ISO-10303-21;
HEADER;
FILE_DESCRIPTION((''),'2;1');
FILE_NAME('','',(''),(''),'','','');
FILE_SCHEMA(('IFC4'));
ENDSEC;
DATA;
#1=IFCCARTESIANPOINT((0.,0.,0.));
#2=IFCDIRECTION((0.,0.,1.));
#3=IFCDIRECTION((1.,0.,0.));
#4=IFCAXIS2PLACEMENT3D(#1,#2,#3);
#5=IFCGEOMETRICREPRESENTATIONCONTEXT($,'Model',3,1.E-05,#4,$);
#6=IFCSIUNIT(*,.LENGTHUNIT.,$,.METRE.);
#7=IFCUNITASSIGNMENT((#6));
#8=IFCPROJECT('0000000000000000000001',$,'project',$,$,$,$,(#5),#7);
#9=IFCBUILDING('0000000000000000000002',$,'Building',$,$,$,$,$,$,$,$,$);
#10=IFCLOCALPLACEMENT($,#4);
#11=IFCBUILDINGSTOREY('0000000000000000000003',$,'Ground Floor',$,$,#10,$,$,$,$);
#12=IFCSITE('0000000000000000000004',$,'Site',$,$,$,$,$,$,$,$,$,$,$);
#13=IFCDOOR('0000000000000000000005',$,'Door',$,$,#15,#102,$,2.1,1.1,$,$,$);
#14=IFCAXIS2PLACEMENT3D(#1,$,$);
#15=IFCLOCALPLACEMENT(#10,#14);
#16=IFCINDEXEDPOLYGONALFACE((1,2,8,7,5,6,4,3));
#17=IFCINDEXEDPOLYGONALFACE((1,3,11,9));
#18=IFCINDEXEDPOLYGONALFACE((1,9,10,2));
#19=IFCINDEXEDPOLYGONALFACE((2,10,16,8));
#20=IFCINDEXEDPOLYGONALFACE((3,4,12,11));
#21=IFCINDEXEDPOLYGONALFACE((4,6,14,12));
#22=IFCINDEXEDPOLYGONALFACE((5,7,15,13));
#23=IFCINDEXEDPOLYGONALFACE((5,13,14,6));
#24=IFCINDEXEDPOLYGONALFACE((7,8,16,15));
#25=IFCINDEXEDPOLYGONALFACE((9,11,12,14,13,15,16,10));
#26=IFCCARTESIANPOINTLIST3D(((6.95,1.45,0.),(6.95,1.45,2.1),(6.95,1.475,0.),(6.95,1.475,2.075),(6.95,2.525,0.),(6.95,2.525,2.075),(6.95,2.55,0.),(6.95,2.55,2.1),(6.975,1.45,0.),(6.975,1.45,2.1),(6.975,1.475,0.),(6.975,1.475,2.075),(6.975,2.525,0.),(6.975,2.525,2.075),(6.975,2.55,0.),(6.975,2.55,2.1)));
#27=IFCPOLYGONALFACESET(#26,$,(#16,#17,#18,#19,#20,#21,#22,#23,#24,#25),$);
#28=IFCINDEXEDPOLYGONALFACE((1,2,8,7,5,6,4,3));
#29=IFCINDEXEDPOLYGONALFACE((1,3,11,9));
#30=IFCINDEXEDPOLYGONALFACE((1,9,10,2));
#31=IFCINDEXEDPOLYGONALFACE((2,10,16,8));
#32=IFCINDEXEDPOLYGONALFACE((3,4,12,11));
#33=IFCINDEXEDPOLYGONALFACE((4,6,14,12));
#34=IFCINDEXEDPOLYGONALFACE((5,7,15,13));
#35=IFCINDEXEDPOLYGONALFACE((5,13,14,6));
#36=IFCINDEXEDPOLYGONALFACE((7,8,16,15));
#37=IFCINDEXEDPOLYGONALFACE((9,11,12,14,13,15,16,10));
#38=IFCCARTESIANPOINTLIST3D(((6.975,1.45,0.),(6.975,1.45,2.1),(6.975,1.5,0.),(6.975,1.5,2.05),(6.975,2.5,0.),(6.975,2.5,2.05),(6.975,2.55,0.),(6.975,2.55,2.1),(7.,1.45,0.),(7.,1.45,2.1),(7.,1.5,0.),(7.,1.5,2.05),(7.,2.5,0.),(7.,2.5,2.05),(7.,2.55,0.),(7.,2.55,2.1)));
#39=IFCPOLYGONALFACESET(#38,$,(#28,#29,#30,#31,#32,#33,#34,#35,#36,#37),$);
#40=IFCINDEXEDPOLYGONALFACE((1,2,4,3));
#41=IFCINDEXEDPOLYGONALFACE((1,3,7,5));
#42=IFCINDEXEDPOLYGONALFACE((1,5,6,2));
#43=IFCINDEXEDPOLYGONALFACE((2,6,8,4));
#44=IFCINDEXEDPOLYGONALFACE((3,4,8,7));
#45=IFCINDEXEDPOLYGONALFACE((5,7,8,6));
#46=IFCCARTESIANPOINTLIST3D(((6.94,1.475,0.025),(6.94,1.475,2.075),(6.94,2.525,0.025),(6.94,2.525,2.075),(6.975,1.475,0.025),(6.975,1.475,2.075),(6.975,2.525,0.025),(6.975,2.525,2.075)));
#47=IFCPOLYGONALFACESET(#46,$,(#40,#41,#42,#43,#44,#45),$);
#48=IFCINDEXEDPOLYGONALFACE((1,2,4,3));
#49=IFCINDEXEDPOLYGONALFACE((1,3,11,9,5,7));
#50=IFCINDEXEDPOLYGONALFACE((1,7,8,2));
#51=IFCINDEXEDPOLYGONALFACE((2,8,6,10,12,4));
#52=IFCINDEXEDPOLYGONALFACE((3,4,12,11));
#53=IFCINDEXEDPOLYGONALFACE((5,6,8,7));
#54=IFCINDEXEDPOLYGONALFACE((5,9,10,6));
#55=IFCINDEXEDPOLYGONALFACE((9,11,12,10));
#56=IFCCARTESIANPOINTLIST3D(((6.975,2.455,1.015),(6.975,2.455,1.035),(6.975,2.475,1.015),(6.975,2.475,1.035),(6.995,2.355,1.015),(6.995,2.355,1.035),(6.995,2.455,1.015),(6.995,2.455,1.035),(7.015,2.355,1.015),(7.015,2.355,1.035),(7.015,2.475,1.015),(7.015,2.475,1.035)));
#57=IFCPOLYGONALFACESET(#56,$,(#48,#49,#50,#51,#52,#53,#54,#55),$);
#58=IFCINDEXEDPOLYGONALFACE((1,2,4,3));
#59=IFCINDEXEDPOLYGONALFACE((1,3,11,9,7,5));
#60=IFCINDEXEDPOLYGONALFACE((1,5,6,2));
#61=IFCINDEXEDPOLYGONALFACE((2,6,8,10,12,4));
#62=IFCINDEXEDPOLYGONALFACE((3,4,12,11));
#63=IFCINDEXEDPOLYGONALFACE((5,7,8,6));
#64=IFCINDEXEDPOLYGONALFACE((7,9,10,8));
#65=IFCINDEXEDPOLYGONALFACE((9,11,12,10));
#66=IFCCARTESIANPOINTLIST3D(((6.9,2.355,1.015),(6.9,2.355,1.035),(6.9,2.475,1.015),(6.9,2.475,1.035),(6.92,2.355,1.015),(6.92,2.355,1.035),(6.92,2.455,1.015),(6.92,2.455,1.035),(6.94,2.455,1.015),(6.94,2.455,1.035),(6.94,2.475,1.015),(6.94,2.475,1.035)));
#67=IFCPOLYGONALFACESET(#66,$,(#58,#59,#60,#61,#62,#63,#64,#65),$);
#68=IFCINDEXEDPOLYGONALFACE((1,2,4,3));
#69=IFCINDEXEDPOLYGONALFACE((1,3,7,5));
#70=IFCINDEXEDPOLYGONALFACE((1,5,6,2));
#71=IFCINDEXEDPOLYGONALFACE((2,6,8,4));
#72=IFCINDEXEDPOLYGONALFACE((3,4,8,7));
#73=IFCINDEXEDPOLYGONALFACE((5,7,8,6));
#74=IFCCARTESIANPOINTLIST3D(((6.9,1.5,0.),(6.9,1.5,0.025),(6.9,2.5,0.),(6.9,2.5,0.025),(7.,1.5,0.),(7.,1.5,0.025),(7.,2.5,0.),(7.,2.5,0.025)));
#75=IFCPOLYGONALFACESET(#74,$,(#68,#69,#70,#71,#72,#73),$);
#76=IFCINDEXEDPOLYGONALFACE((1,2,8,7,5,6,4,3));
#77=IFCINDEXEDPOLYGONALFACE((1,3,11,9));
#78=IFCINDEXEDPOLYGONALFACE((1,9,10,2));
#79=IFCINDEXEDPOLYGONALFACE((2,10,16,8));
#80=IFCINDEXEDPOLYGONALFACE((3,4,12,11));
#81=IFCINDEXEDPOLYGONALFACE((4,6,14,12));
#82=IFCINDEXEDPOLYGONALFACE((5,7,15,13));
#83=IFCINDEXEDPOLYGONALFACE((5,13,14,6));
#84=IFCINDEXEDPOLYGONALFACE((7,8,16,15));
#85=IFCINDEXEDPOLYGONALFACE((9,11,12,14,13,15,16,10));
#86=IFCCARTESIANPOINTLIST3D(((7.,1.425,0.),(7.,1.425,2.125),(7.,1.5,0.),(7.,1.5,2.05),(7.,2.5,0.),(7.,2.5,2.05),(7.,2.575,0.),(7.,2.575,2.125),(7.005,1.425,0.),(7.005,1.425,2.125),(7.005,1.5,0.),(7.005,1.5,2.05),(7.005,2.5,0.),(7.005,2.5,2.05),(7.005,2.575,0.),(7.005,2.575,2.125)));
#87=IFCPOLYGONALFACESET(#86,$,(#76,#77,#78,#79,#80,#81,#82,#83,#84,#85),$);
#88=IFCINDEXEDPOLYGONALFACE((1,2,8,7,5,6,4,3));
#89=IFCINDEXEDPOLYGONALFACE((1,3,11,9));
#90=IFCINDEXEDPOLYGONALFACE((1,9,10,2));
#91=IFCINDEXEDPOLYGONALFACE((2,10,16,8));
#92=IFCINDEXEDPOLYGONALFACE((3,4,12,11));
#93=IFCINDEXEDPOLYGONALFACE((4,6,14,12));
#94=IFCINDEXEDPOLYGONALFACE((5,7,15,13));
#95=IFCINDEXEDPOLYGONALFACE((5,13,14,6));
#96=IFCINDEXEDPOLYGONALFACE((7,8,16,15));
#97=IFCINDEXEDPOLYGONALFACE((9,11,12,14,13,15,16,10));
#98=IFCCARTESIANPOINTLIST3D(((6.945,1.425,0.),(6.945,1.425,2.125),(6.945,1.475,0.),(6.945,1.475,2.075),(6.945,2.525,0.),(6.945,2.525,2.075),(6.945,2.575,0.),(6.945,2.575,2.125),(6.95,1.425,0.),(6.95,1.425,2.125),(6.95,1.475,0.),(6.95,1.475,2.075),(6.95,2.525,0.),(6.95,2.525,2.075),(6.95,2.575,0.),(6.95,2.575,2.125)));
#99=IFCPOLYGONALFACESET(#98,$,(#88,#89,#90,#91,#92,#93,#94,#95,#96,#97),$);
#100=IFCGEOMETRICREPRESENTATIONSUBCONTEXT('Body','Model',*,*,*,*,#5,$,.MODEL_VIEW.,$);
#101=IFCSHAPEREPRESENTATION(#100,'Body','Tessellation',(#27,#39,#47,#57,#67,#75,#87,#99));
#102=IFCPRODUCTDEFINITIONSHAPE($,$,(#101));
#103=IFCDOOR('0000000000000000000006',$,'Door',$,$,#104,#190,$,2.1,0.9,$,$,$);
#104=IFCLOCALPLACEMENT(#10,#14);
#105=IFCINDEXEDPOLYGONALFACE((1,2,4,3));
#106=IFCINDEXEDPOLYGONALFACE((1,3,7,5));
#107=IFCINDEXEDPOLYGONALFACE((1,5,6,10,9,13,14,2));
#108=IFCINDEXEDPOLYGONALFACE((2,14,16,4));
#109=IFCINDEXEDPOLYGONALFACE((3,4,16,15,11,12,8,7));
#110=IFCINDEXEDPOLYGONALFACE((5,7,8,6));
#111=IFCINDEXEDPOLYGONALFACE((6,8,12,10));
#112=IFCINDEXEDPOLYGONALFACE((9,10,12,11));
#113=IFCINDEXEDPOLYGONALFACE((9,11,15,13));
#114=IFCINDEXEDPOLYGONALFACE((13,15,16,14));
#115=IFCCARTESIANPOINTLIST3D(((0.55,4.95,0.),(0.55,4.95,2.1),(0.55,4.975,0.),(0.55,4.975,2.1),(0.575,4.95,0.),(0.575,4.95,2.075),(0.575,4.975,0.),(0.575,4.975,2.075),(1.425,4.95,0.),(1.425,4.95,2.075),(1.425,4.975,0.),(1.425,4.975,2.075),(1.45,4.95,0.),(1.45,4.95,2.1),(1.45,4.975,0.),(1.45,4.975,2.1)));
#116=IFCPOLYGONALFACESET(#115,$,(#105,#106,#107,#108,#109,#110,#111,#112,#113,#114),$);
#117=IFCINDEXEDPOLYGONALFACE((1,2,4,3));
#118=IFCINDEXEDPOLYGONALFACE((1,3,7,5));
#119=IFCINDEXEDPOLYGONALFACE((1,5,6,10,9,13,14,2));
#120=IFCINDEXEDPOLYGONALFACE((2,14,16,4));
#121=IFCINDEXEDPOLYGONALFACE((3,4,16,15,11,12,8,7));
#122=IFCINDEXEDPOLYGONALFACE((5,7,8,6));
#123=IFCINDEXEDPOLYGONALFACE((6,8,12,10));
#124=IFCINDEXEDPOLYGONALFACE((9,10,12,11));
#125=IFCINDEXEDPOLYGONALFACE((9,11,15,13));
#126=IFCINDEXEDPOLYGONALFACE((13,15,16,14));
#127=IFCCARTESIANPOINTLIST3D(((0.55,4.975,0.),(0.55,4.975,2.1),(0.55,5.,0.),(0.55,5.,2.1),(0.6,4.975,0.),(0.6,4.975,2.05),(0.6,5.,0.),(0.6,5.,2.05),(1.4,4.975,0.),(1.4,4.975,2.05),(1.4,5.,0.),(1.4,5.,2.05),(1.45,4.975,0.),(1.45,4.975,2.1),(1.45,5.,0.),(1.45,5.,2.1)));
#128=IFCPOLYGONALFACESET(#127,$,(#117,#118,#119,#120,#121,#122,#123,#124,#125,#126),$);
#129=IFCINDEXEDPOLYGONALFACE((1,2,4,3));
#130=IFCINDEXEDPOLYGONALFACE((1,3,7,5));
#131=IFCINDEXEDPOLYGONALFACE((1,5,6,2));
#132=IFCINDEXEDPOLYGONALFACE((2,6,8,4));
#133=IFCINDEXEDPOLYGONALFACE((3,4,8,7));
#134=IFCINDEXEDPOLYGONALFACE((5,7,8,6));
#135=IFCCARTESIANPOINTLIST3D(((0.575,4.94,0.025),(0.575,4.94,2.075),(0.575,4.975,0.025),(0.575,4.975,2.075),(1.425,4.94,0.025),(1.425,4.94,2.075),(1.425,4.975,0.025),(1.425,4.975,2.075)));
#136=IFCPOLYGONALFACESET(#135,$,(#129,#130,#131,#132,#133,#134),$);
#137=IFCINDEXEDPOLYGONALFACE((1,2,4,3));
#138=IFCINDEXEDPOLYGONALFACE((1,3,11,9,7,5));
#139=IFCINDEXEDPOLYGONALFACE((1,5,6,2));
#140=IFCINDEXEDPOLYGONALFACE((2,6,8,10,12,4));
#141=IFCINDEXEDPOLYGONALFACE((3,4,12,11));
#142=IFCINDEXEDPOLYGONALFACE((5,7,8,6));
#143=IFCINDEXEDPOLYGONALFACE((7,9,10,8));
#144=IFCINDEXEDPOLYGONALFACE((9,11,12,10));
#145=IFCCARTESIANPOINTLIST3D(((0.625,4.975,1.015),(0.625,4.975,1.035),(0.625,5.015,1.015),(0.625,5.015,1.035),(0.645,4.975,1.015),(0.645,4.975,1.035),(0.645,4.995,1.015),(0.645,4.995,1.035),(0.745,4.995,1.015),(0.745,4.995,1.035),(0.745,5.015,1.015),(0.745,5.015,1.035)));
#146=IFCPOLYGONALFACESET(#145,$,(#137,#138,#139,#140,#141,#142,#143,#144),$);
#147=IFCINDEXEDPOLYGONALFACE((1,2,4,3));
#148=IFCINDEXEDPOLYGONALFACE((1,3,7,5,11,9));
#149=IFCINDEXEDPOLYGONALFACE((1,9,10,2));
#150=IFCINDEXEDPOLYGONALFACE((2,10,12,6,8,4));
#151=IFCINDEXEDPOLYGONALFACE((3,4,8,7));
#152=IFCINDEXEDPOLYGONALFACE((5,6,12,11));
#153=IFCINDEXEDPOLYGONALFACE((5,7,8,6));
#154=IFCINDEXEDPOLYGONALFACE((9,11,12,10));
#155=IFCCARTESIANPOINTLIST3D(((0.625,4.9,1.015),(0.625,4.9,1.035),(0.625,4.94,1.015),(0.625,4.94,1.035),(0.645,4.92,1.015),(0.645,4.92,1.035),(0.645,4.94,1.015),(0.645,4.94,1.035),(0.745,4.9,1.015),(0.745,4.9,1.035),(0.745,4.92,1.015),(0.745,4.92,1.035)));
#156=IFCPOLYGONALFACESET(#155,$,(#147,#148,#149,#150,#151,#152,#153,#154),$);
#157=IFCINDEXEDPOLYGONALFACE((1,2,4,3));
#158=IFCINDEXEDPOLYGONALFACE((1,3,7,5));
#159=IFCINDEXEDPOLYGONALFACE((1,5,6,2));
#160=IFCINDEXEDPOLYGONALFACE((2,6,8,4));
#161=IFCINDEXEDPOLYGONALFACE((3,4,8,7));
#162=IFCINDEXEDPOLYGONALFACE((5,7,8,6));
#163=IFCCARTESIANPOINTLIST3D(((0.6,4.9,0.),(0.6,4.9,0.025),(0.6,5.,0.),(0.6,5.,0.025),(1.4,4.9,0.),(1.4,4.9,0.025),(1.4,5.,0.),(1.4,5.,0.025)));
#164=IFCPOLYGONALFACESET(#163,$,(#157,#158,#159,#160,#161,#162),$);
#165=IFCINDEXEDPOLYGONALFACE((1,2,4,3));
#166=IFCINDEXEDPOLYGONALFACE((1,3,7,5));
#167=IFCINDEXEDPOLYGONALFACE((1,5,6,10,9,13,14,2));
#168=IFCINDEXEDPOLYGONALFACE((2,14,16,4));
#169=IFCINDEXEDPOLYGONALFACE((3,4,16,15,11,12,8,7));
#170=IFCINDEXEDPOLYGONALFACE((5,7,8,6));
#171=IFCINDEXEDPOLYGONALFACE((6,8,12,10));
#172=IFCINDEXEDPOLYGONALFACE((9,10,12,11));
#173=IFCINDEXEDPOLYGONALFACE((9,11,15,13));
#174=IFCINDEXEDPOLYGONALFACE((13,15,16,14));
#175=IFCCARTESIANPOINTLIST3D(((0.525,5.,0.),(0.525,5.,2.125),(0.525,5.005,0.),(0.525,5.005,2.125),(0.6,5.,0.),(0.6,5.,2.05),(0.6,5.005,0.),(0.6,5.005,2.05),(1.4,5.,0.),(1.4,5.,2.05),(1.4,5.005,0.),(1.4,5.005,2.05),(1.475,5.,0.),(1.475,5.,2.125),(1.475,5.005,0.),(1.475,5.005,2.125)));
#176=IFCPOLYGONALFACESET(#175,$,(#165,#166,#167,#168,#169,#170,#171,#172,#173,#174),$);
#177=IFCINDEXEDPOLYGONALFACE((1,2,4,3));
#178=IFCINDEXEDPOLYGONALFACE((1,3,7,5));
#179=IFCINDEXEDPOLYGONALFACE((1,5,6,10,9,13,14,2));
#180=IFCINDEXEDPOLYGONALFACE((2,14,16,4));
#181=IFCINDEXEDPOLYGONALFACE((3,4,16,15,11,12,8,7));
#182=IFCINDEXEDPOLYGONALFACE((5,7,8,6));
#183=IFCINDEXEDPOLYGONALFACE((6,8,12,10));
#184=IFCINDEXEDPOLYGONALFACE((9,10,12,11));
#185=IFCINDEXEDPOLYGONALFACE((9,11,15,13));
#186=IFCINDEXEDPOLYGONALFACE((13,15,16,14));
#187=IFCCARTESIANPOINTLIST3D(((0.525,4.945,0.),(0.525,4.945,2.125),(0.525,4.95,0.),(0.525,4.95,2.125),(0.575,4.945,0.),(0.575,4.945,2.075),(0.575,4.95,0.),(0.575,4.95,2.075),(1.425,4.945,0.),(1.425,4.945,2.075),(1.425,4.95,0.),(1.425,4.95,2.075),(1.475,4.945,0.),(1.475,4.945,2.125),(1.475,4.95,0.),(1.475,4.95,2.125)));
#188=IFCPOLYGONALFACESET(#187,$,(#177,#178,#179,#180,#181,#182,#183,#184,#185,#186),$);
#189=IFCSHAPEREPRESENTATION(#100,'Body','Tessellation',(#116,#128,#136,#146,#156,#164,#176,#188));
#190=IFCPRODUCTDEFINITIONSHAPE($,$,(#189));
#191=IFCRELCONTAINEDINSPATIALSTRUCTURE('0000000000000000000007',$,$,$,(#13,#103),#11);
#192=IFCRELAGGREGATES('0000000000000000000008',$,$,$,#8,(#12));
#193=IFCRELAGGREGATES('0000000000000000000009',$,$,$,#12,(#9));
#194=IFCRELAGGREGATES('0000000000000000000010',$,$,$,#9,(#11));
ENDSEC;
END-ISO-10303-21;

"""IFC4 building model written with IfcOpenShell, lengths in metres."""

from ifc_helpers import new_model, si_unit, frame, origin_with_axes, place, context, subcontext, project, spatial, line, indexed_curve, outline, extrude, element, save


model = new_model("IFC4")

# Units and contexts
model_context = context("Model", 3, precision=1e-05, world=origin_with_axes())
body_context = subcontext(model_context, "Body", "Model", "MODEL_VIEW")
ifc_project = project(units=[si_unit("LENGTHUNIT", "METRE")], contexts=[model_context])

# Site, building, storey
site = spatial("IfcSite", under=ifc_project, Name="Site")
building = spatial("IfcBuilding", under=site, Name="Building")
storey_placement = place(None, origin_with_axes())
storey = spatial("IfcBuildingStorey", under=building, at=storey_placement, Name="Ground Floor")

# Doors
door_1_placement = place(storey_placement, frame((7.0, 1.45, 0.0), z_axis=(0.0, 0.0, 1.0), x_axis=(0.0, 1.0, 0.0)))
element("IfcDoor", 1, at=door_1_placement, inside=storey, Name="Door", OverallHeight=2.1, OverallWidth=1.1, context=body_context, shape_type="SweptSolid", body=[
    extrude(outline(indexed_curve([(0.0, 0.0), (0.0, 2.1), (1.1, 2.1), (1.1, 0.0), (1.075, 0.0), (1.075, 2.075), (0.025, 2.075), (0.025, 0.0)], segments=[line(1, 2, 3, 4, 5, 6, 7, 8, 1)])), frame((0.0, 0.025, 0.0), z_axis=(0.0, -1.0, 0.0), x_axis=(1.0, 0.0, 0.0)), (0.0, 0.0, -1.0), 0.025),
    extrude(outline(indexed_curve([(0.0, 0.0), (0.0, 2.1), (1.1, 2.1), (1.1, 0.0), (1.05, 0.0), (1.05, 2.05), (0.05, 2.05), (0.05, 0.0)], segments=[line(1, 2, 3, 4, 5, 6, 7, 8, 1)])), frame((0.0, 0.0, 0.0), z_axis=(0.0, -1.0, 0.0), x_axis=(1.0, 0.0, 0.0)), (0.0, 0.0, -1.0), 0.025),
    extrude(outline(indexed_curve([(0.0, 0.0), (1.05, 0.0), (1.05, 0.035), (0.0, 0.035)], segments=[line(1, 2, 3, 4, 1)])), frame((0.025, 0.025, 0.025), z_axis=(0.0, 0.0, 1.0), x_axis=(1.0, 0.0, 0.0)), (0.0, 0.0, 1.0), 2.05),
    extrude(outline(indexed_curve([(0.0, 0.0), (0.0, -0.04), (-0.12, -0.04), (-0.12, -0.02), (-0.02, -0.02), (-0.02, 0.0)], segments=[line(1, 2, 3, 4, 5, 6, 1)])), frame((1.025, 0.025, 1.015), z_axis=(0.0, 0.0, 1.0), x_axis=(1.0, 0.0, 0.0)), (0.0, 0.0, 1.0), 0.02),
    extrude(outline(indexed_curve([(0.0, 0.0), (0.0, 0.04), (-0.12, 0.04), (-0.12, 0.02), (-0.02, 0.02), (-0.02, 0.0)], segments=[line(1, 2, 3, 4, 5, 6, 1)])), frame((1.025, 0.06, 1.015), z_axis=(0.0, 0.0, 1.0), x_axis=(1.0, 0.0, 0.0)), (0.0, 0.0, 1.0), 0.02),
    extrude(outline(indexed_curve([(0.0, 0.0), (1.0, 0.0), (1.0, 0.1), (0.0, 0.1)], segments=[line(1, 2, 3, 4, 1)])), frame((0.05, 0.0, 0.0), z_axis=(0.0, 0.0, 1.0), x_axis=(1.0, 0.0, 0.0)), (0.0, 0.0, 1.0), 0.025),
    extrude(outline(indexed_curve([(0.0, 0.0), (0.0, 2.125), (1.15, 2.125), (1.15, 0.0), (1.075, 0.0), (1.075, 2.05), (0.075, 2.05), (0.075, 0.0)], segments=[line(1, 2, 3, 4, 5, 6, 7, 8, 1)])), frame((-0.025, -0.005, 0.0), z_axis=(0.0, -1.0, 0.0), x_axis=(1.0, 0.0, 0.0)), (0.0, 0.0, -1.0), 0.005),
    extrude(outline(indexed_curve([(0.0, 0.0), (0.0, 2.125), (1.15, 2.125), (1.15, 0.0), (1.1, 0.0), (1.1, 2.075), (0.05, 2.075), (0.05, 0.0)], segments=[line(1, 2, 3, 4, 5, 6, 7, 8, 1)])), frame((-0.025, 0.05, 0.0), z_axis=(0.0, -1.0, 0.0), x_axis=(1.0, 0.0, 0.0)), (0.0, 0.0, -1.0), 0.005),
])
door_2_placement = place(storey_placement, frame((1.45, 5.0, 0.0), z_axis=(0.0, 0.0, 1.0), x_axis=(-1.0, 0.0, 0.0)))
element("IfcDoor", 2, at=door_2_placement, inside=storey, Name="Door", OverallHeight=2.1, OverallWidth=0.9, context=body_context, shape_type="SweptSolid", body=[
    extrude(outline(indexed_curve([(0.0, 0.0), (0.0, 2.1), (0.9, 2.1), (0.9, 0.0), (0.875, 0.0), (0.875, 2.075), (0.025, 2.075), (0.025, 0.0)], segments=[line(1, 2, 3, 4, 5, 6, 7, 8, 1)])), frame((0.0, 0.025, 0.0), z_axis=(0.0, -1.0, 0.0), x_axis=(1.0, 0.0, 0.0)), (0.0, 0.0, -1.0), 0.025),
    extrude(outline(indexed_curve([(0.0, 0.0), (0.0, 2.1), (0.9, 2.1), (0.9, 0.0), (0.85, 0.0), (0.85, 2.05), (0.05, 2.05), (0.05, 0.0)], segments=[line(1, 2, 3, 4, 5, 6, 7, 8, 1)])), frame((0.0, 0.0, 0.0), z_axis=(0.0, -1.0, 0.0), x_axis=(1.0, 0.0, 0.0)), (0.0, 0.0, -1.0), 0.025),
    extrude(outline(indexed_curve([(0.0, 0.0), (0.85, 0.0), (0.85, 0.035), (0.0, 0.035)], segments=[line(1, 2, 3, 4, 1)])), frame((0.025, 0.025, 0.025), z_axis=(0.0, 0.0, 1.0), x_axis=(1.0, 0.0, 0.0)), (0.0, 0.0, 1.0), 2.05),
    extrude(outline(indexed_curve([(0.0, 0.0), (0.0, -0.04), (-0.12, -0.04), (-0.12, -0.02), (-0.02, -0.02), (-0.02, 0.0)], segments=[line(1, 2, 3, 4, 5, 6, 1)])), frame((0.825, 0.025, 1.015), z_axis=(0.0, 0.0, 1.0), x_axis=(1.0, 0.0, 0.0)), (0.0, 0.0, 1.0), 0.02),
    extrude(outline(indexed_curve([(0.0, 0.0), (0.0, 0.04), (-0.12, 0.04), (-0.12, 0.02), (-0.02, 0.02), (-0.02, 0.0)], segments=[line(1, 2, 3, 4, 5, 6, 1)])), frame((0.825, 0.06, 1.015), z_axis=(0.0, 0.0, 1.0), x_axis=(1.0, 0.0, 0.0)), (0.0, 0.0, 1.0), 0.02),
    extrude(outline(indexed_curve([(0.0, 0.0), (0.8, 0.0), (0.8, 0.1), (0.0, 0.1)], segments=[line(1, 2, 3, 4, 1)])), frame((0.05, 0.0, 0.0), z_axis=(0.0, 0.0, 1.0), x_axis=(1.0, 0.0, 0.0)), (0.0, 0.0, 1.0), 0.025),
    extrude(outline(indexed_curve([(0.0, 0.0), (0.0, 2.125), (0.95, 2.125), (0.95, 0.0), (0.875, 0.0), (0.875, 2.05), (0.075, 2.05), (0.075, 0.0)], segments=[line(1, 2, 3, 4, 5, 6, 7, 8, 1)])), frame((-0.025, -0.005, 0.0), z_axis=(0.0, -1.0, 0.0), x_axis=(1.0, 0.0, 0.0)), (0.0, 0.0, -1.0), 0.005),
    extrude(outline(indexed_curve([(0.0, 0.0), (0.0, 2.125), (0.95, 2.125), (0.95, 0.0), (0.9, 0.0), (0.9, 2.075), (0.05, 2.075), (0.05, 0.0)], segments=[line(1, 2, 3, 4, 5, 6, 7, 8, 1)])), frame((-0.025, 0.05, 0.0), z_axis=(0.0, -1.0, 0.0), x_axis=(1.0, 0.0, 0.0)), (0.0, 0.0, -1.0), 0.005),
])

save(model, "model.ifc")
